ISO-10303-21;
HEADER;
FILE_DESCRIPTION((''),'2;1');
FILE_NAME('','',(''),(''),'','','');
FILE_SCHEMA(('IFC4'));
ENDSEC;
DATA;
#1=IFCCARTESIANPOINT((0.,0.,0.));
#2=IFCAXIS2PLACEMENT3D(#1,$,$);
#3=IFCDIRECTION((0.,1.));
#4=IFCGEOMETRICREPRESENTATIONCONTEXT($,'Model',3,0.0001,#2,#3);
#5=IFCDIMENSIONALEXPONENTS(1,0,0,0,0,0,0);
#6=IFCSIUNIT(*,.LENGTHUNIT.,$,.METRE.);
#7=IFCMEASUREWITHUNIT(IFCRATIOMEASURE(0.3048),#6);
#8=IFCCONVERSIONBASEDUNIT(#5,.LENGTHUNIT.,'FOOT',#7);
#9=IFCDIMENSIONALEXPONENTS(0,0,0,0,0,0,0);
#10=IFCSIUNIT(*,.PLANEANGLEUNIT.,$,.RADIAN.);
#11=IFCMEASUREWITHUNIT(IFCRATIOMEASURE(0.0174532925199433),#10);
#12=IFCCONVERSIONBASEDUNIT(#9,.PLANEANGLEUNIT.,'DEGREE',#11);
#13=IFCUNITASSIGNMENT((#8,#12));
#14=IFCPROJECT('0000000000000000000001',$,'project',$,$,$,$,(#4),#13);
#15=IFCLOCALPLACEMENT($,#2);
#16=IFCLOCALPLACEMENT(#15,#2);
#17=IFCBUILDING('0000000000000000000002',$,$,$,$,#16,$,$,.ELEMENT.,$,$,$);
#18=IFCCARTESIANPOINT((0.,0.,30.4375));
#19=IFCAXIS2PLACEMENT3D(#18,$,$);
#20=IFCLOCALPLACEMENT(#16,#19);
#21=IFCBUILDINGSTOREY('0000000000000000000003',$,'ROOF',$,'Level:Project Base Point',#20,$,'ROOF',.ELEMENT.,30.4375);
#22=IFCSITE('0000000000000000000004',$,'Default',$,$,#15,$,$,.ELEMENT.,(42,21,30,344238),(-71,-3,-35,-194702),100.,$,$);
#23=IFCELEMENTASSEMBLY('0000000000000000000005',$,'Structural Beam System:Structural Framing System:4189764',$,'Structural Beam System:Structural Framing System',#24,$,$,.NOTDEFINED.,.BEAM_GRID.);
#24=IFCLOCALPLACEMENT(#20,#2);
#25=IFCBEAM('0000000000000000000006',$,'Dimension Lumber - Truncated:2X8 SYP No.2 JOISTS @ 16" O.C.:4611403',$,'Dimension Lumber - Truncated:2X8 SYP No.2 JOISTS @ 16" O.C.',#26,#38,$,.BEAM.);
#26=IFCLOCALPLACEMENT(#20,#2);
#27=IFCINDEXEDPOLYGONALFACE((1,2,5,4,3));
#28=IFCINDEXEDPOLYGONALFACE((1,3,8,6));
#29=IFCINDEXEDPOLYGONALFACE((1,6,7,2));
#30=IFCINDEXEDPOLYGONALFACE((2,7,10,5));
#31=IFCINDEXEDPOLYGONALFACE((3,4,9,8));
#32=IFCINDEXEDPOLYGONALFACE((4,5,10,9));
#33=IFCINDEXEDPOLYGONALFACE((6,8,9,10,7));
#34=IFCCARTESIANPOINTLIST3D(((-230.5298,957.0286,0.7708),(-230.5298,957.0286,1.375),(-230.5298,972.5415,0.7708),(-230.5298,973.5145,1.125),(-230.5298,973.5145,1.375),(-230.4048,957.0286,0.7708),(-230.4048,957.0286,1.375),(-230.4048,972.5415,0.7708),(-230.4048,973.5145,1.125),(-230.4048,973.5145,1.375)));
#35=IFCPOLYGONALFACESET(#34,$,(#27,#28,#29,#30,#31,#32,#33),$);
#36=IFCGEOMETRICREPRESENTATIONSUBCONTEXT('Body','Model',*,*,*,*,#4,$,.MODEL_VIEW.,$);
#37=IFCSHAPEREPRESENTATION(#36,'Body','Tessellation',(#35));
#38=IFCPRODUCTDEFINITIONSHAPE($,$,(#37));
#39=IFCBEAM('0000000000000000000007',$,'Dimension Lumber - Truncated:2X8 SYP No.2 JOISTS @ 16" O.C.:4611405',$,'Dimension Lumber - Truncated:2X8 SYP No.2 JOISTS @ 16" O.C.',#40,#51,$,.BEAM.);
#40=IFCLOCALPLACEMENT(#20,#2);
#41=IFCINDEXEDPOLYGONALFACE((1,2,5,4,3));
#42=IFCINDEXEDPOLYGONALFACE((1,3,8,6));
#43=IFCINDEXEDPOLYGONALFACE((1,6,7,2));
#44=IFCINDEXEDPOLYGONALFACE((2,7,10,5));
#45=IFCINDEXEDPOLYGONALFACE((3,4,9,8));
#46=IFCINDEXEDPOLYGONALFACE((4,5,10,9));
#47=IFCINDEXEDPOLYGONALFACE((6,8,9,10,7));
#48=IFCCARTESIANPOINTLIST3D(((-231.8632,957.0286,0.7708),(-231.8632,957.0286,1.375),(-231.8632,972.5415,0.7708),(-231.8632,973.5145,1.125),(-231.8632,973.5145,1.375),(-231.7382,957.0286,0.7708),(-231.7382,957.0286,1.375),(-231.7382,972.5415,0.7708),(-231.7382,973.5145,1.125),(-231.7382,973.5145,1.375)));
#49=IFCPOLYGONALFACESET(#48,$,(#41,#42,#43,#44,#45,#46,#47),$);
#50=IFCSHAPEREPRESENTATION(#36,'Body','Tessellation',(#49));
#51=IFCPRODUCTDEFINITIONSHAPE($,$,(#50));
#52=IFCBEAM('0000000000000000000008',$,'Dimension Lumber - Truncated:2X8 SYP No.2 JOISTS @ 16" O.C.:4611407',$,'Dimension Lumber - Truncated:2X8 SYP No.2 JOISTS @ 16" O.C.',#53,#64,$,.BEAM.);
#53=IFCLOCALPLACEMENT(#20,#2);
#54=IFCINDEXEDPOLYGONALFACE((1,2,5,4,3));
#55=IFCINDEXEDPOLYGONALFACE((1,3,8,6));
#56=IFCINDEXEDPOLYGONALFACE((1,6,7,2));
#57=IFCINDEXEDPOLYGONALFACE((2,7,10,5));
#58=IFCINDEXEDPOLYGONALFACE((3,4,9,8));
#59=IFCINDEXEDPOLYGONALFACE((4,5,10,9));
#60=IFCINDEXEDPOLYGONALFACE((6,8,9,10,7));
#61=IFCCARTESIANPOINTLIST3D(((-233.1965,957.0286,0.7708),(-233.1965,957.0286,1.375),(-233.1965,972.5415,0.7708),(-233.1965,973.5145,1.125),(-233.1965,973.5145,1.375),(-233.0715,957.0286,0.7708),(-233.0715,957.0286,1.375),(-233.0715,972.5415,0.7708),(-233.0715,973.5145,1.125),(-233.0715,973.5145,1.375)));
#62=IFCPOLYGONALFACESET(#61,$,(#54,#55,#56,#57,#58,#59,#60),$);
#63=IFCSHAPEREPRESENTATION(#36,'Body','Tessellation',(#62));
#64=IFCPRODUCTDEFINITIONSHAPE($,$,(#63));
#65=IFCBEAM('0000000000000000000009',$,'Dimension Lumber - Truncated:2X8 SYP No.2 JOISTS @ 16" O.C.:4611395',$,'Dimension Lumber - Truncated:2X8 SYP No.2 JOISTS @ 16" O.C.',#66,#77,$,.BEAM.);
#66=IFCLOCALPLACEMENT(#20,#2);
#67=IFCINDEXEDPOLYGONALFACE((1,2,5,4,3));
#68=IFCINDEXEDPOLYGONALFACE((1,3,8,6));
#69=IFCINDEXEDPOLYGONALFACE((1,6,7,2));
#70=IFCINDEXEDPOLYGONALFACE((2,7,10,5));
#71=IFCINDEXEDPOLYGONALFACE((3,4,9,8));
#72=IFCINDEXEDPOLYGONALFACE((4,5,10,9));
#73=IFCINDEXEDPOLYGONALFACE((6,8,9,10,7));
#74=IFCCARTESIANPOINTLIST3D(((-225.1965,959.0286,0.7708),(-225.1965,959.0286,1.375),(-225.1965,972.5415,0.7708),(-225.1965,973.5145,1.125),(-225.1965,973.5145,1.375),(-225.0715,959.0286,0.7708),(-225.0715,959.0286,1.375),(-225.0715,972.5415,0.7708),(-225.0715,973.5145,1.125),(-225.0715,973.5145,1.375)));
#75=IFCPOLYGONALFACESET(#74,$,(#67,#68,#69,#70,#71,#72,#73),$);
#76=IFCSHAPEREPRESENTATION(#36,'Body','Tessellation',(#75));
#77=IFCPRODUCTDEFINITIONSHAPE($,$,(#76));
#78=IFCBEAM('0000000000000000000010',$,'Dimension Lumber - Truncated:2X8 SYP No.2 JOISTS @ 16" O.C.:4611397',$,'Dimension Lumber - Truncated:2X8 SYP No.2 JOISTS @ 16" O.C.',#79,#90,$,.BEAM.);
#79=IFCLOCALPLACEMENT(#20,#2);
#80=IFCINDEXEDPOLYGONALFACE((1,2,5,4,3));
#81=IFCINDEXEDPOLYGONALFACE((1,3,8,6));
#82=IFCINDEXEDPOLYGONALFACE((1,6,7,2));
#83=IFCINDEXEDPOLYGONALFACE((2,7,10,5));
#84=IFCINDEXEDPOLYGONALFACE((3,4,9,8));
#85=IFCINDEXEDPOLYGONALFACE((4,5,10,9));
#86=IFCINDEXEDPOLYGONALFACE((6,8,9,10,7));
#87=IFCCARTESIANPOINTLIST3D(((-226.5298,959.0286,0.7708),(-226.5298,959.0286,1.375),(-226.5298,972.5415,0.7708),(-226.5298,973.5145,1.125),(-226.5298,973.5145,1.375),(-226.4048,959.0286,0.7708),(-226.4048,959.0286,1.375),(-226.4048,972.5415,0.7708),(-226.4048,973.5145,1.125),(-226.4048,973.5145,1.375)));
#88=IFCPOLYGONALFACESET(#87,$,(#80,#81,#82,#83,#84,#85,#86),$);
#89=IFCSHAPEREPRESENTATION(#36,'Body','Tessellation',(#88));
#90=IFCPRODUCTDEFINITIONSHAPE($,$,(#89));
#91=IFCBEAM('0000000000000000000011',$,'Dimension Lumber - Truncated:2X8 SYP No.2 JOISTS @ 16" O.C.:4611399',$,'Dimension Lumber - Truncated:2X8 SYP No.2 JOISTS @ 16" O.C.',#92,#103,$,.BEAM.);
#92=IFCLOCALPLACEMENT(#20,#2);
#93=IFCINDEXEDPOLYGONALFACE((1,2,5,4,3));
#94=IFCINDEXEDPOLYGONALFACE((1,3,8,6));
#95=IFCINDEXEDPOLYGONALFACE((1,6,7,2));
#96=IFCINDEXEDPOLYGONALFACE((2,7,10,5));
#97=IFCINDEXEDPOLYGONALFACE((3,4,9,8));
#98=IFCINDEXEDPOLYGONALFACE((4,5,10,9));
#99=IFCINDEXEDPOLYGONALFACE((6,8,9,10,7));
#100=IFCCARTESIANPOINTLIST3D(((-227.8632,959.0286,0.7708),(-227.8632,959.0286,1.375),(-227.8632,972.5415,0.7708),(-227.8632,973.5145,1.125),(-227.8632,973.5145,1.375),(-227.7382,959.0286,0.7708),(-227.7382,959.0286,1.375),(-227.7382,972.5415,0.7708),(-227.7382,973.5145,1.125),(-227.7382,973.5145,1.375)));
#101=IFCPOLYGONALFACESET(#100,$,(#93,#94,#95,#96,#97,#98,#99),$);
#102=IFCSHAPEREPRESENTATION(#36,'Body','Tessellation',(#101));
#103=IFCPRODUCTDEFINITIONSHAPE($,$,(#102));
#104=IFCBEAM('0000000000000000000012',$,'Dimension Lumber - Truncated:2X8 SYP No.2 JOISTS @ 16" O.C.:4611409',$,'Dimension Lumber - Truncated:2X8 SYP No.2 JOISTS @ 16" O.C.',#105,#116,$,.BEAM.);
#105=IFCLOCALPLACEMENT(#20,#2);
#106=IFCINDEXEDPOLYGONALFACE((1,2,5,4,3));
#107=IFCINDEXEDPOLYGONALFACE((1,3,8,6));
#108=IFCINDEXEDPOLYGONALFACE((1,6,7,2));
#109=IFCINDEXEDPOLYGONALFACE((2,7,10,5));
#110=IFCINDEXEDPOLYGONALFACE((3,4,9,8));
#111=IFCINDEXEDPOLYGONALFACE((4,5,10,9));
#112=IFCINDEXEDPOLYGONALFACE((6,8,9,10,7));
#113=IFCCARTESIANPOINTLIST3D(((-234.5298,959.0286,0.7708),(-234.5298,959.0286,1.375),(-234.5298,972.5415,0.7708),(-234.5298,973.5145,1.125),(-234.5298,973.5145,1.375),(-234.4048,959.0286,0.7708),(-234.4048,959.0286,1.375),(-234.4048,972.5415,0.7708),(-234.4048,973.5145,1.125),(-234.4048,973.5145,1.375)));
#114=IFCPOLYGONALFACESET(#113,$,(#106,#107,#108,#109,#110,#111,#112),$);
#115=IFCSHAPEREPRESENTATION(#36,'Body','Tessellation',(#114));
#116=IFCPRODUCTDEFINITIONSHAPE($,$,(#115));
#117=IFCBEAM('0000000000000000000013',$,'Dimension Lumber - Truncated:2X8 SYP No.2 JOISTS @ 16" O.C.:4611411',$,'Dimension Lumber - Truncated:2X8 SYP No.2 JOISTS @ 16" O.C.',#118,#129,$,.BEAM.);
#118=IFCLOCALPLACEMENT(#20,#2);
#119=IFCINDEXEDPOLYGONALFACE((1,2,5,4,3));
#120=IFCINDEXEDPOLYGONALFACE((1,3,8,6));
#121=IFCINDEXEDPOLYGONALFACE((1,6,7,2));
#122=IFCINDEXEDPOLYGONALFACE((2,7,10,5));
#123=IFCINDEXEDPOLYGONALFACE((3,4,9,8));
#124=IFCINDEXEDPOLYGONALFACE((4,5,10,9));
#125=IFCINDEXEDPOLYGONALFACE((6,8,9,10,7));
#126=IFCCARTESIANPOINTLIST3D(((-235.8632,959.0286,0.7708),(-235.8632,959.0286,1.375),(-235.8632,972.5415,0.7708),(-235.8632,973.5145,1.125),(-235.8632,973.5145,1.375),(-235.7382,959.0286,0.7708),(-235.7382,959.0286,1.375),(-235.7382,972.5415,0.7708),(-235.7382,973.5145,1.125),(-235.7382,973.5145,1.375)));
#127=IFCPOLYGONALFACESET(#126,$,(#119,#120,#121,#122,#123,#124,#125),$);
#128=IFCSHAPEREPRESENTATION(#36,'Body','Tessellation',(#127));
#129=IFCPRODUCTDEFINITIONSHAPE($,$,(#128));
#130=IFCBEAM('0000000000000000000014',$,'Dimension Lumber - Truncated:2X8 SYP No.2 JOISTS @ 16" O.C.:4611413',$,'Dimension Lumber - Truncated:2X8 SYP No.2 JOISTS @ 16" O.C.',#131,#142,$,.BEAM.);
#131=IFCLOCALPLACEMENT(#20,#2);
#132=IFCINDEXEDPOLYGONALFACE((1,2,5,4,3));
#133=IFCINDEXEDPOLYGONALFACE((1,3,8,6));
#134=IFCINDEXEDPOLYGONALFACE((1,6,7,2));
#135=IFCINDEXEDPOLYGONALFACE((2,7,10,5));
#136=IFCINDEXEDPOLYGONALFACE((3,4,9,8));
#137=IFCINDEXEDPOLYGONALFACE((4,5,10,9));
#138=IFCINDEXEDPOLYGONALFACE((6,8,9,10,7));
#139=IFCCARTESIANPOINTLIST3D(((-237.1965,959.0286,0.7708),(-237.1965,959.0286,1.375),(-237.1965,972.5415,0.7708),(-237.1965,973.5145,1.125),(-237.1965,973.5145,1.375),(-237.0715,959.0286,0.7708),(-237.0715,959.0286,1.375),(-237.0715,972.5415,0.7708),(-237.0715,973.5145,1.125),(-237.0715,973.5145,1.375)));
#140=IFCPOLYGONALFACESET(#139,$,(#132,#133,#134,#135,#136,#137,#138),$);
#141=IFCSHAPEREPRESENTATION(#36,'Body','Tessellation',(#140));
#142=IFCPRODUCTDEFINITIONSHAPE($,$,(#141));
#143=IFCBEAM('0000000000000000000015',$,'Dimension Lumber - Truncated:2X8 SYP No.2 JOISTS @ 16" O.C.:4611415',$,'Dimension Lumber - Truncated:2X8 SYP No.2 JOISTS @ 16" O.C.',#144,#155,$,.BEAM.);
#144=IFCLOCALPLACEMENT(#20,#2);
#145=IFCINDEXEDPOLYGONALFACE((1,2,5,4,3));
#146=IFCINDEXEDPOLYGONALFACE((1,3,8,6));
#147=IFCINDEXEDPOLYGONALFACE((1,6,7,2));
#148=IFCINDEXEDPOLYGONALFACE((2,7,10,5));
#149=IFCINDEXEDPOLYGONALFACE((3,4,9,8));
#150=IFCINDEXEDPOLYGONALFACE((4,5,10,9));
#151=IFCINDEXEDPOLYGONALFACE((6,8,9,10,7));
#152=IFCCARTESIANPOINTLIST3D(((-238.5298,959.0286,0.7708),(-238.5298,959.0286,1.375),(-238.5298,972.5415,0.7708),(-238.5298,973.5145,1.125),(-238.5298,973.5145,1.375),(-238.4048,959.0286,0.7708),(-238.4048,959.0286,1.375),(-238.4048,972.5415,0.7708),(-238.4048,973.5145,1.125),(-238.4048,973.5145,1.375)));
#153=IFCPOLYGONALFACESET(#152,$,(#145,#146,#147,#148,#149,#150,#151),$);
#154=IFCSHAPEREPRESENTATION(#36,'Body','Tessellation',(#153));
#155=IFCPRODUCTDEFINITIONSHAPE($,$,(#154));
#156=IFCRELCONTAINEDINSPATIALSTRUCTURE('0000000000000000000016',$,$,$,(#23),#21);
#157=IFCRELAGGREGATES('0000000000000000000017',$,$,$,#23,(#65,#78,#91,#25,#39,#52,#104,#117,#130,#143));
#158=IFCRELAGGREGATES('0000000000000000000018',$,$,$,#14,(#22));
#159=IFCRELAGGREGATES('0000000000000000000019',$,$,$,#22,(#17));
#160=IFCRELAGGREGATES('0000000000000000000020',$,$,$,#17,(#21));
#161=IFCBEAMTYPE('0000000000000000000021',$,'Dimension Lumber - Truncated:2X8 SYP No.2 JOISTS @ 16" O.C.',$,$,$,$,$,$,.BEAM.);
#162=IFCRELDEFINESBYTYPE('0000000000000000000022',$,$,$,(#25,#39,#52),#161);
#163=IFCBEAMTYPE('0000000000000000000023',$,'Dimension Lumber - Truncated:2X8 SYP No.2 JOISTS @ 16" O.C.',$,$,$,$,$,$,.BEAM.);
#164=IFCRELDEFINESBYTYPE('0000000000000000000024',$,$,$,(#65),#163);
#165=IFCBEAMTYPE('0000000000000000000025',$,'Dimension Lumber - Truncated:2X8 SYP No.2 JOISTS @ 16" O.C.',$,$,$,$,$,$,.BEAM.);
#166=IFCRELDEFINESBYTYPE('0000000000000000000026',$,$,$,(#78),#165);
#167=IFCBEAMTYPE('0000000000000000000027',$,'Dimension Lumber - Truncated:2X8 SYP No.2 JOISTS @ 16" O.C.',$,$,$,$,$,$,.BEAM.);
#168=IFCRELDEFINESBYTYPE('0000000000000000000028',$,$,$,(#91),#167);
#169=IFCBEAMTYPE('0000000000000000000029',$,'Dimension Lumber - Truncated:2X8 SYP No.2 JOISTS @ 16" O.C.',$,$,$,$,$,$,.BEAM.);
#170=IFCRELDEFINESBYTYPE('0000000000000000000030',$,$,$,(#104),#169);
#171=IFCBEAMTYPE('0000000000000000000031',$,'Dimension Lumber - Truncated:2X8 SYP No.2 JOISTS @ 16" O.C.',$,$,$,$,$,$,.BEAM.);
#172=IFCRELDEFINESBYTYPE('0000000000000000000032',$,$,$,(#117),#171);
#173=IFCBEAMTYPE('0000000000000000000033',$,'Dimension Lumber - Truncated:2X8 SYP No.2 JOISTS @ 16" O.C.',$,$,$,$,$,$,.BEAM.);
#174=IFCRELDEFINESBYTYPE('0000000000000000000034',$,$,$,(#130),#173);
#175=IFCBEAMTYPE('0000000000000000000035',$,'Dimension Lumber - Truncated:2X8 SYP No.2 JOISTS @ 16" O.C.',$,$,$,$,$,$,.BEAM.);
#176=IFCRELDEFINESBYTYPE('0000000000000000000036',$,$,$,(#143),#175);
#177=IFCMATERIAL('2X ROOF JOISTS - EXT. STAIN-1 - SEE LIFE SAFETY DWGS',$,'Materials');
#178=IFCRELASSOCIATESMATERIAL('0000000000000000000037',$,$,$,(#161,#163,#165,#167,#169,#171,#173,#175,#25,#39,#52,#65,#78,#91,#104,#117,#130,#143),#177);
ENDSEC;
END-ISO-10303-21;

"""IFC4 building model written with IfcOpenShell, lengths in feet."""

from ifc_helpers import new_model, entity, si_unit, converted_unit, direction, frame, frame_2d, origin, place, context, subcontext, project, spatial, rectangle, extrude, clip, halfspace, source, transform, mapped, material, material_profile, profile_set, profile_usage, type_object, type_shapes, element, aggregate, save


model = new_model("IFC4")

# Units and contexts
model_context = context("Model", 3, precision=0.0001, world=origin(), true_north=direction((0.0, 1.0)))
body_context = subcontext(model_context, "Body", "Model", "MODEL_VIEW")
ifc_project = project(units=[converted_unit("LENGTHUNIT", "FOOT", entity("IfcRatioMeasure", 0.3048), si_unit("LENGTHUNIT", "METRE"), dimensions=[1, 0, 0, 0, 0, 0, 0]), converted_unit("PLANEANGLEUNIT", "DEGREE", entity("IfcRatioMeasure", 0.0174532925199433), si_unit("PLANEANGLEUNIT", "RADIAN"), dimensions=[0, 0, 0, 0, 0, 0, 0])], contexts=[model_context])

# Site, building, storey
site_placement = place(None, origin())
site = spatial("IfcSite", under=ifc_project, at=site_placement, Name="Default", CompositionType="ELEMENT", RefLatitude=(42, 21, 30, 344238), RefLongitude=(-71, -3, -35, -194702), RefElevation=100.0)
building_placement = place(site_placement, origin())
building = spatial("IfcBuilding", under=site, at=building_placement, CompositionType="ELEMENT")
storey_placement = place(building_placement, frame((0.0, 0.0, 30.4375)))
storey = spatial("IfcBuildingStorey", under=building, at=storey_placement, Name="ROOF", ObjectType="Level:Project Base Point", LongName="ROOF", CompositionType="ELEMENT", Elevation=30.4375)

# Element assembly, beams
assembly_1_placement = place(storey_placement, origin())
assembly_1 = element("IfcElementAssembly", 1, at=assembly_1_placement, inside=storey, Name="Structural Beam System:Structural Framing System:4189764", ObjectType="Structural Beam System:Structural Framing System", AssemblyPlace="NOTDEFINED", PredefinedType="BEAM_GRID")
ifc_material_1 = material(Name="2X ROOF JOISTS - EXT. STAIN-1 - SEE LIFE SAFETY DWGS", Category="Materials")
ifc_material_profile_1 = material_profile(ifc_material_1, rectangle(XDim=0.6042, YDim=0.125, at=frame_2d((0.0, 0.0), x_axis=(0.0, 1.0))), Name="2X8 SYP No.2 JOISTS @ 16\" O.C.")
ifc_profile_set_1 = profile_set([ifc_material_profile_1], Name="2X8 SYP No.2 JOISTS @ 16\" O.C.")
beam_type_1 = type_object("IfcBeamType", Name="Dimension Lumber - Truncated:2X8 SYP No.2 JOISTS @ 16\" O.C.", PredefinedType="BEAM", material=ifc_profile_set_1)
shared_shape_1 = source(origin(), body_context, "Body", "Clipping", [
    clip(extrude(rectangle(XDim=0.6042, YDim=0.125, at=frame_2d((0.0, 0.0), x_axis=(0.0, 1.0))), frame((-8.243, 0.0, 0.0), z_axis=(1.0, 0.0, 0.0), x_axis=(0.0, 1.0, 0.0)), (0.0, 0.0, 1.0), 16.4859), halfspace(frame((-7.2699, -0.0625, -0.3021), z_axis=(-0.34202, 0.0, -0.939693), x_axis=(0.0, 1.0, 0.0)), False)),
])
type_shapes(beam_type_1, [shared_shape_1])
ifc_profile_usage_1 = profile_usage(ifc_profile_set_1, cardinal=8)
beam_1_placement = place(assembly_1_placement, frame((-230.4673, 965.2716, 1.0729), z_axis=(0.0, 0.0, 1.0), x_axis=(0.0, -1.0, 0.0)))
beam_1 = element("IfcBeam", 2, at=beam_1_placement, type_object=beam_type_1, material=ifc_profile_usage_1, Name="Dimension Lumber - Truncated:2X8 SYP No.2 JOISTS @ 16\" O.C.:4611403", ObjectType="Dimension Lumber - Truncated:2X8 SYP No.2 JOISTS @ 16\" O.C.", PredefinedType="BEAM", context=body_context, shape_type="MappedRepresentation", body=[
    mapped(shared_shape_1, transform((0.0, 0.0, 0.0), scale=1.0)),
])
ifc_profile_usage_2 = profile_usage(ifc_profile_set_1, cardinal=8)
beam_2_placement = place(assembly_1_placement, frame((-231.8007, 965.2716, 1.0729), z_axis=(0.0, 0.0, 1.0), x_axis=(0.0, -1.0, 0.0)))
beam_2 = element("IfcBeam", 3, at=beam_2_placement, type_object=beam_type_1, material=ifc_profile_usage_2, Name="Dimension Lumber - Truncated:2X8 SYP No.2 JOISTS @ 16\" O.C.:4611405", ObjectType="Dimension Lumber - Truncated:2X8 SYP No.2 JOISTS @ 16\" O.C.", PredefinedType="BEAM", context=body_context, shape_type="MappedRepresentation", body=[
    mapped(shared_shape_1, transform((0.0, 0.0, 0.0), scale=1.0)),
])
ifc_profile_usage_3 = profile_usage(ifc_profile_set_1, cardinal=8)
beam_3_placement = place(assembly_1_placement, frame((-233.134, 965.2716, 1.0729), z_axis=(0.0, 0.0, 1.0), x_axis=(0.0, -1.0, 0.0)))
beam_3 = element("IfcBeam", 4, at=beam_3_placement, type_object=beam_type_1, material=ifc_profile_usage_3, Name="Dimension Lumber - Truncated:2X8 SYP No.2 JOISTS @ 16\" O.C.:4611407", ObjectType="Dimension Lumber - Truncated:2X8 SYP No.2 JOISTS @ 16\" O.C.", PredefinedType="BEAM", context=body_context, shape_type="MappedRepresentation", body=[
    mapped(shared_shape_1, transform((0.0, 0.0, 0.0), scale=1.0)),
])
ifc_profile_usage_4 = profile_usage(ifc_profile_set_1, cardinal=8)
beam_type_2 = type_object("IfcBeamType", Name="Dimension Lumber - Truncated:2X8 SYP No.2 JOISTS @ 16\" O.C.", PredefinedType="BEAM", material=ifc_profile_set_1)
shared_shape_2 = source(origin(), body_context, "Body", "Clipping", [
    clip(extrude(rectangle(XDim=0.6042, YDim=0.125, at=frame_2d((0.0, 0.0), x_axis=(0.0, 1.0))), frame((-7.243, 0.0, 0.0), z_axis=(1.0, 0.0, 0.0), x_axis=(0.0, 1.0, 0.0)), (0.0, 0.0, 1.0), 14.4859), halfspace(frame((-6.2699, -0.0625, -0.3021), z_axis=(-0.34202, 0.0, -0.939693), x_axis=(0.0, 1.0, 0.0)), False)),
])
type_shapes(beam_type_2, [shared_shape_2])
beam_4_placement = place(assembly_1_placement, frame((-225.134, 966.2716, 1.0729), z_axis=(0.0, 0.0, 1.0), x_axis=(0.0, -1.0, 0.0)))
beam_4 = element("IfcBeam", 5, at=beam_4_placement, type_object=beam_type_2, material=ifc_profile_usage_4, Name="Dimension Lumber - Truncated:2X8 SYP No.2 JOISTS @ 16\" O.C.:4611395", ObjectType="Dimension Lumber - Truncated:2X8 SYP No.2 JOISTS @ 16\" O.C.", PredefinedType="BEAM", context=body_context, shape_type="MappedRepresentation", body=[
    mapped(shared_shape_2, transform((0.0, 0.0, 0.0), scale=1.0)),
])
ifc_profile_usage_5 = profile_usage(ifc_profile_set_1, cardinal=8)
beam_type_3 = type_object("IfcBeamType", Name="Dimension Lumber - Truncated:2X8 SYP No.2 JOISTS @ 16\" O.C.", PredefinedType="BEAM", material=ifc_profile_set_1)
shared_shape_3 = source(origin(), body_context, "Body", "Clipping", [
    clip(extrude(rectangle(XDim=0.6042, YDim=0.125, at=frame_2d((0.0, 0.0), x_axis=(0.0, 1.0))), frame((-7.243, 0.0, 0.0), z_axis=(1.0, 0.0, 0.0), x_axis=(0.0, 1.0, 0.0)), (0.0, 0.0, 1.0), 14.4859), halfspace(frame((-6.2699, -0.0625, -0.3021), z_axis=(-0.34202, 0.0, -0.939693), x_axis=(0.0, 1.0, 0.0)), False)),
])
type_shapes(beam_type_3, [shared_shape_3])
beam_5_placement = place(assembly_1_placement, frame((-226.4673, 966.2716, 1.0729), z_axis=(0.0, 0.0, 1.0), x_axis=(0.0, -1.0, 0.0)))
beam_5 = element("IfcBeam", 6, at=beam_5_placement, type_object=beam_type_3, material=ifc_profile_usage_5, Name="Dimension Lumber - Truncated:2X8 SYP No.2 JOISTS @ 16\" O.C.:4611397", ObjectType="Dimension Lumber - Truncated:2X8 SYP No.2 JOISTS @ 16\" O.C.", PredefinedType="BEAM", context=body_context, shape_type="MappedRepresentation", body=[
    mapped(shared_shape_3, transform((0.0, 0.0, 0.0), scale=1.0)),
])
ifc_profile_usage_6 = profile_usage(ifc_profile_set_1, cardinal=8)
beam_type_4 = type_object("IfcBeamType", Name="Dimension Lumber - Truncated:2X8 SYP No.2 JOISTS @ 16\" O.C.", PredefinedType="BEAM", material=ifc_profile_set_1)
shared_shape_4 = source(origin(), body_context, "Body", "Clipping", [
    clip(extrude(rectangle(XDim=0.6042, YDim=0.125, at=frame_2d((0.0, 0.0), x_axis=(0.0, 1.0))), frame((-7.243, 0.0, 0.0), z_axis=(1.0, 0.0, 0.0), x_axis=(0.0, 1.0, 0.0)), (0.0, 0.0, 1.0), 14.4859), halfspace(frame((-6.2699, -0.0625, -0.3021), z_axis=(-0.34202, 0.0, -0.939693), x_axis=(0.0, 1.0, 0.0)), False)),
])
type_shapes(beam_type_4, [shared_shape_4])
beam_6_placement = place(assembly_1_placement, frame((-227.8007, 966.2716, 1.0729), z_axis=(0.0, 0.0, 1.0), x_axis=(0.0, -1.0, 0.0)))
beam_6 = element("IfcBeam", 7, at=beam_6_placement, type_object=beam_type_4, material=ifc_profile_usage_6, Name="Dimension Lumber - Truncated:2X8 SYP No.2 JOISTS @ 16\" O.C.:4611399", ObjectType="Dimension Lumber - Truncated:2X8 SYP No.2 JOISTS @ 16\" O.C.", PredefinedType="BEAM", context=body_context, shape_type="MappedRepresentation", body=[
    mapped(shared_shape_4, transform((0.0, 0.0, 0.0), scale=1.0)),
])
ifc_profile_usage_7 = profile_usage(ifc_profile_set_1, cardinal=8)
beam_type_5 = type_object("IfcBeamType", Name="Dimension Lumber - Truncated:2X8 SYP No.2 JOISTS @ 16\" O.C.", PredefinedType="BEAM", material=ifc_profile_set_1)
shared_shape_5 = source(origin(), body_context, "Body", "Clipping", [
    clip(extrude(rectangle(XDim=0.6042, YDim=0.125, at=frame_2d((0.0, 0.0), x_axis=(0.0, 1.0))), frame((-7.243, 0.0, 0.0), z_axis=(1.0, 0.0, 0.0), x_axis=(0.0, 1.0, 0.0)), (0.0, 0.0, 1.0), 14.4859), halfspace(frame((-6.2699, -0.0625, -0.3021), z_axis=(-0.34202, 0.0, -0.939693), x_axis=(0.0, 1.0, 0.0)), False)),
])
type_shapes(beam_type_5, [shared_shape_5])
beam_7_placement = place(assembly_1_placement, frame((-234.4673, 966.2716, 1.0729), z_axis=(0.0, 0.0, 1.0), x_axis=(0.0, -1.0, 0.0)))
beam_7 = element("IfcBeam", 8, at=beam_7_placement, type_object=beam_type_5, material=ifc_profile_usage_7, Name="Dimension Lumber - Truncated:2X8 SYP No.2 JOISTS @ 16\" O.C.:4611409", ObjectType="Dimension Lumber - Truncated:2X8 SYP No.2 JOISTS @ 16\" O.C.", PredefinedType="BEAM", context=body_context, shape_type="MappedRepresentation", body=[
    mapped(shared_shape_5, transform((0.0, 0.0, 0.0), scale=1.0)),
])
ifc_profile_usage_8 = profile_usage(ifc_profile_set_1, cardinal=8)
beam_type_6 = type_object("IfcBeamType", Name="Dimension Lumber - Truncated:2X8 SYP No.2 JOISTS @ 16\" O.C.", PredefinedType="BEAM", material=ifc_profile_set_1)
shared_shape_6 = source(origin(), body_context, "Body", "Clipping", [
    clip(extrude(rectangle(XDim=0.6042, YDim=0.125, at=frame_2d((0.0, 0.0), x_axis=(0.0, 1.0))), frame((-7.243, 0.0, 0.0), z_axis=(1.0, 0.0, 0.0), x_axis=(0.0, 1.0, 0.0)), (0.0, 0.0, 1.0), 14.4859), halfspace(frame((-6.2699, -0.0625, -0.3021), z_axis=(-0.34202, 0.0, -0.939693), x_axis=(0.0, 1.0, 0.0)), False)),
])
type_shapes(beam_type_6, [shared_shape_6])
beam_8_placement = place(assembly_1_placement, frame((-235.8007, 966.2716, 1.0729), z_axis=(0.0, 0.0, 1.0), x_axis=(0.0, -1.0, 0.0)))
beam_8 = element("IfcBeam", 9, at=beam_8_placement, type_object=beam_type_6, material=ifc_profile_usage_8, Name="Dimension Lumber - Truncated:2X8 SYP No.2 JOISTS @ 16\" O.C.:4611411", ObjectType="Dimension Lumber - Truncated:2X8 SYP No.2 JOISTS @ 16\" O.C.", PredefinedType="BEAM", context=body_context, shape_type="MappedRepresentation", body=[
    mapped(shared_shape_6, transform((0.0, 0.0, 0.0), scale=1.0)),
])
ifc_profile_usage_9 = profile_usage(ifc_profile_set_1, cardinal=8)
beam_type_7 = type_object("IfcBeamType", Name="Dimension Lumber - Truncated:2X8 SYP No.2 JOISTS @ 16\" O.C.", PredefinedType="BEAM", material=ifc_profile_set_1)
shared_shape_7 = source(origin(), body_context, "Body", "Clipping", [
    clip(extrude(rectangle(XDim=0.6042, YDim=0.125, at=frame_2d((0.0, 0.0), x_axis=(0.0, 1.0))), frame((-7.243, 0.0, 0.0), z_axis=(1.0, 0.0, 0.0), x_axis=(0.0, 1.0, 0.0)), (0.0, 0.0, 1.0), 14.4859), halfspace(frame((-6.2699, -0.0625, -0.3021), z_axis=(-0.34202, 0.0, -0.939693), x_axis=(0.0, 1.0, 0.0)), False)),
])
type_shapes(beam_type_7, [shared_shape_7])
beam_9_placement = place(assembly_1_placement, frame((-237.134, 966.2716, 1.0729), z_axis=(0.0, 0.0, 1.0), x_axis=(0.0, -1.0, 0.0)))
beam_9 = element("IfcBeam", 10, at=beam_9_placement, type_object=beam_type_7, material=ifc_profile_usage_9, Name="Dimension Lumber - Truncated:2X8 SYP No.2 JOISTS @ 16\" O.C.:4611413", ObjectType="Dimension Lumber - Truncated:2X8 SYP No.2 JOISTS @ 16\" O.C.", PredefinedType="BEAM", context=body_context, shape_type="MappedRepresentation", body=[
    mapped(shared_shape_7, transform((0.0, 0.0, 0.0), scale=1.0)),
])
ifc_profile_usage_10 = profile_usage(ifc_profile_set_1, cardinal=8)
beam_type_8 = type_object("IfcBeamType", Name="Dimension Lumber - Truncated:2X8 SYP No.2 JOISTS @ 16\" O.C.", PredefinedType="BEAM", material=ifc_profile_set_1)
shared_shape_8 = source(origin(), body_context, "Body", "Clipping", [
    clip(extrude(rectangle(XDim=0.6042, YDim=0.125, at=frame_2d((0.0, 0.0), x_axis=(0.0, 1.0))), frame((-7.243, 0.0, 0.0), z_axis=(1.0, 0.0, 0.0), x_axis=(0.0, 1.0, 0.0)), (0.0, 0.0, 1.0), 14.4859), halfspace(frame((-6.2699, -0.0625, -0.3021), z_axis=(-0.34202, 0.0, -0.939693), x_axis=(0.0, 1.0, 0.0)), False)),
])
type_shapes(beam_type_8, [shared_shape_8])
beam_10_placement = place(assembly_1_placement, frame((-238.4673, 966.2716, 1.0729), z_axis=(0.0, 0.0, 1.0), x_axis=(0.0, -1.0, 0.0)))
beam_10 = element("IfcBeam", 11, at=beam_10_placement, type_object=beam_type_8, material=ifc_profile_usage_10, Name="Dimension Lumber - Truncated:2X8 SYP No.2 JOISTS @ 16\" O.C.:4611415", ObjectType="Dimension Lumber - Truncated:2X8 SYP No.2 JOISTS @ 16\" O.C.", PredefinedType="BEAM", context=body_context, shape_type="MappedRepresentation", body=[
    mapped(shared_shape_8, transform((0.0, 0.0, 0.0), scale=1.0)),
])
aggregate(assembly_1, [beam_4, beam_5, beam_6, beam_1, beam_2, beam_3, beam_7, beam_8, beam_9, beam_10])

save(model, "model.ifc")
